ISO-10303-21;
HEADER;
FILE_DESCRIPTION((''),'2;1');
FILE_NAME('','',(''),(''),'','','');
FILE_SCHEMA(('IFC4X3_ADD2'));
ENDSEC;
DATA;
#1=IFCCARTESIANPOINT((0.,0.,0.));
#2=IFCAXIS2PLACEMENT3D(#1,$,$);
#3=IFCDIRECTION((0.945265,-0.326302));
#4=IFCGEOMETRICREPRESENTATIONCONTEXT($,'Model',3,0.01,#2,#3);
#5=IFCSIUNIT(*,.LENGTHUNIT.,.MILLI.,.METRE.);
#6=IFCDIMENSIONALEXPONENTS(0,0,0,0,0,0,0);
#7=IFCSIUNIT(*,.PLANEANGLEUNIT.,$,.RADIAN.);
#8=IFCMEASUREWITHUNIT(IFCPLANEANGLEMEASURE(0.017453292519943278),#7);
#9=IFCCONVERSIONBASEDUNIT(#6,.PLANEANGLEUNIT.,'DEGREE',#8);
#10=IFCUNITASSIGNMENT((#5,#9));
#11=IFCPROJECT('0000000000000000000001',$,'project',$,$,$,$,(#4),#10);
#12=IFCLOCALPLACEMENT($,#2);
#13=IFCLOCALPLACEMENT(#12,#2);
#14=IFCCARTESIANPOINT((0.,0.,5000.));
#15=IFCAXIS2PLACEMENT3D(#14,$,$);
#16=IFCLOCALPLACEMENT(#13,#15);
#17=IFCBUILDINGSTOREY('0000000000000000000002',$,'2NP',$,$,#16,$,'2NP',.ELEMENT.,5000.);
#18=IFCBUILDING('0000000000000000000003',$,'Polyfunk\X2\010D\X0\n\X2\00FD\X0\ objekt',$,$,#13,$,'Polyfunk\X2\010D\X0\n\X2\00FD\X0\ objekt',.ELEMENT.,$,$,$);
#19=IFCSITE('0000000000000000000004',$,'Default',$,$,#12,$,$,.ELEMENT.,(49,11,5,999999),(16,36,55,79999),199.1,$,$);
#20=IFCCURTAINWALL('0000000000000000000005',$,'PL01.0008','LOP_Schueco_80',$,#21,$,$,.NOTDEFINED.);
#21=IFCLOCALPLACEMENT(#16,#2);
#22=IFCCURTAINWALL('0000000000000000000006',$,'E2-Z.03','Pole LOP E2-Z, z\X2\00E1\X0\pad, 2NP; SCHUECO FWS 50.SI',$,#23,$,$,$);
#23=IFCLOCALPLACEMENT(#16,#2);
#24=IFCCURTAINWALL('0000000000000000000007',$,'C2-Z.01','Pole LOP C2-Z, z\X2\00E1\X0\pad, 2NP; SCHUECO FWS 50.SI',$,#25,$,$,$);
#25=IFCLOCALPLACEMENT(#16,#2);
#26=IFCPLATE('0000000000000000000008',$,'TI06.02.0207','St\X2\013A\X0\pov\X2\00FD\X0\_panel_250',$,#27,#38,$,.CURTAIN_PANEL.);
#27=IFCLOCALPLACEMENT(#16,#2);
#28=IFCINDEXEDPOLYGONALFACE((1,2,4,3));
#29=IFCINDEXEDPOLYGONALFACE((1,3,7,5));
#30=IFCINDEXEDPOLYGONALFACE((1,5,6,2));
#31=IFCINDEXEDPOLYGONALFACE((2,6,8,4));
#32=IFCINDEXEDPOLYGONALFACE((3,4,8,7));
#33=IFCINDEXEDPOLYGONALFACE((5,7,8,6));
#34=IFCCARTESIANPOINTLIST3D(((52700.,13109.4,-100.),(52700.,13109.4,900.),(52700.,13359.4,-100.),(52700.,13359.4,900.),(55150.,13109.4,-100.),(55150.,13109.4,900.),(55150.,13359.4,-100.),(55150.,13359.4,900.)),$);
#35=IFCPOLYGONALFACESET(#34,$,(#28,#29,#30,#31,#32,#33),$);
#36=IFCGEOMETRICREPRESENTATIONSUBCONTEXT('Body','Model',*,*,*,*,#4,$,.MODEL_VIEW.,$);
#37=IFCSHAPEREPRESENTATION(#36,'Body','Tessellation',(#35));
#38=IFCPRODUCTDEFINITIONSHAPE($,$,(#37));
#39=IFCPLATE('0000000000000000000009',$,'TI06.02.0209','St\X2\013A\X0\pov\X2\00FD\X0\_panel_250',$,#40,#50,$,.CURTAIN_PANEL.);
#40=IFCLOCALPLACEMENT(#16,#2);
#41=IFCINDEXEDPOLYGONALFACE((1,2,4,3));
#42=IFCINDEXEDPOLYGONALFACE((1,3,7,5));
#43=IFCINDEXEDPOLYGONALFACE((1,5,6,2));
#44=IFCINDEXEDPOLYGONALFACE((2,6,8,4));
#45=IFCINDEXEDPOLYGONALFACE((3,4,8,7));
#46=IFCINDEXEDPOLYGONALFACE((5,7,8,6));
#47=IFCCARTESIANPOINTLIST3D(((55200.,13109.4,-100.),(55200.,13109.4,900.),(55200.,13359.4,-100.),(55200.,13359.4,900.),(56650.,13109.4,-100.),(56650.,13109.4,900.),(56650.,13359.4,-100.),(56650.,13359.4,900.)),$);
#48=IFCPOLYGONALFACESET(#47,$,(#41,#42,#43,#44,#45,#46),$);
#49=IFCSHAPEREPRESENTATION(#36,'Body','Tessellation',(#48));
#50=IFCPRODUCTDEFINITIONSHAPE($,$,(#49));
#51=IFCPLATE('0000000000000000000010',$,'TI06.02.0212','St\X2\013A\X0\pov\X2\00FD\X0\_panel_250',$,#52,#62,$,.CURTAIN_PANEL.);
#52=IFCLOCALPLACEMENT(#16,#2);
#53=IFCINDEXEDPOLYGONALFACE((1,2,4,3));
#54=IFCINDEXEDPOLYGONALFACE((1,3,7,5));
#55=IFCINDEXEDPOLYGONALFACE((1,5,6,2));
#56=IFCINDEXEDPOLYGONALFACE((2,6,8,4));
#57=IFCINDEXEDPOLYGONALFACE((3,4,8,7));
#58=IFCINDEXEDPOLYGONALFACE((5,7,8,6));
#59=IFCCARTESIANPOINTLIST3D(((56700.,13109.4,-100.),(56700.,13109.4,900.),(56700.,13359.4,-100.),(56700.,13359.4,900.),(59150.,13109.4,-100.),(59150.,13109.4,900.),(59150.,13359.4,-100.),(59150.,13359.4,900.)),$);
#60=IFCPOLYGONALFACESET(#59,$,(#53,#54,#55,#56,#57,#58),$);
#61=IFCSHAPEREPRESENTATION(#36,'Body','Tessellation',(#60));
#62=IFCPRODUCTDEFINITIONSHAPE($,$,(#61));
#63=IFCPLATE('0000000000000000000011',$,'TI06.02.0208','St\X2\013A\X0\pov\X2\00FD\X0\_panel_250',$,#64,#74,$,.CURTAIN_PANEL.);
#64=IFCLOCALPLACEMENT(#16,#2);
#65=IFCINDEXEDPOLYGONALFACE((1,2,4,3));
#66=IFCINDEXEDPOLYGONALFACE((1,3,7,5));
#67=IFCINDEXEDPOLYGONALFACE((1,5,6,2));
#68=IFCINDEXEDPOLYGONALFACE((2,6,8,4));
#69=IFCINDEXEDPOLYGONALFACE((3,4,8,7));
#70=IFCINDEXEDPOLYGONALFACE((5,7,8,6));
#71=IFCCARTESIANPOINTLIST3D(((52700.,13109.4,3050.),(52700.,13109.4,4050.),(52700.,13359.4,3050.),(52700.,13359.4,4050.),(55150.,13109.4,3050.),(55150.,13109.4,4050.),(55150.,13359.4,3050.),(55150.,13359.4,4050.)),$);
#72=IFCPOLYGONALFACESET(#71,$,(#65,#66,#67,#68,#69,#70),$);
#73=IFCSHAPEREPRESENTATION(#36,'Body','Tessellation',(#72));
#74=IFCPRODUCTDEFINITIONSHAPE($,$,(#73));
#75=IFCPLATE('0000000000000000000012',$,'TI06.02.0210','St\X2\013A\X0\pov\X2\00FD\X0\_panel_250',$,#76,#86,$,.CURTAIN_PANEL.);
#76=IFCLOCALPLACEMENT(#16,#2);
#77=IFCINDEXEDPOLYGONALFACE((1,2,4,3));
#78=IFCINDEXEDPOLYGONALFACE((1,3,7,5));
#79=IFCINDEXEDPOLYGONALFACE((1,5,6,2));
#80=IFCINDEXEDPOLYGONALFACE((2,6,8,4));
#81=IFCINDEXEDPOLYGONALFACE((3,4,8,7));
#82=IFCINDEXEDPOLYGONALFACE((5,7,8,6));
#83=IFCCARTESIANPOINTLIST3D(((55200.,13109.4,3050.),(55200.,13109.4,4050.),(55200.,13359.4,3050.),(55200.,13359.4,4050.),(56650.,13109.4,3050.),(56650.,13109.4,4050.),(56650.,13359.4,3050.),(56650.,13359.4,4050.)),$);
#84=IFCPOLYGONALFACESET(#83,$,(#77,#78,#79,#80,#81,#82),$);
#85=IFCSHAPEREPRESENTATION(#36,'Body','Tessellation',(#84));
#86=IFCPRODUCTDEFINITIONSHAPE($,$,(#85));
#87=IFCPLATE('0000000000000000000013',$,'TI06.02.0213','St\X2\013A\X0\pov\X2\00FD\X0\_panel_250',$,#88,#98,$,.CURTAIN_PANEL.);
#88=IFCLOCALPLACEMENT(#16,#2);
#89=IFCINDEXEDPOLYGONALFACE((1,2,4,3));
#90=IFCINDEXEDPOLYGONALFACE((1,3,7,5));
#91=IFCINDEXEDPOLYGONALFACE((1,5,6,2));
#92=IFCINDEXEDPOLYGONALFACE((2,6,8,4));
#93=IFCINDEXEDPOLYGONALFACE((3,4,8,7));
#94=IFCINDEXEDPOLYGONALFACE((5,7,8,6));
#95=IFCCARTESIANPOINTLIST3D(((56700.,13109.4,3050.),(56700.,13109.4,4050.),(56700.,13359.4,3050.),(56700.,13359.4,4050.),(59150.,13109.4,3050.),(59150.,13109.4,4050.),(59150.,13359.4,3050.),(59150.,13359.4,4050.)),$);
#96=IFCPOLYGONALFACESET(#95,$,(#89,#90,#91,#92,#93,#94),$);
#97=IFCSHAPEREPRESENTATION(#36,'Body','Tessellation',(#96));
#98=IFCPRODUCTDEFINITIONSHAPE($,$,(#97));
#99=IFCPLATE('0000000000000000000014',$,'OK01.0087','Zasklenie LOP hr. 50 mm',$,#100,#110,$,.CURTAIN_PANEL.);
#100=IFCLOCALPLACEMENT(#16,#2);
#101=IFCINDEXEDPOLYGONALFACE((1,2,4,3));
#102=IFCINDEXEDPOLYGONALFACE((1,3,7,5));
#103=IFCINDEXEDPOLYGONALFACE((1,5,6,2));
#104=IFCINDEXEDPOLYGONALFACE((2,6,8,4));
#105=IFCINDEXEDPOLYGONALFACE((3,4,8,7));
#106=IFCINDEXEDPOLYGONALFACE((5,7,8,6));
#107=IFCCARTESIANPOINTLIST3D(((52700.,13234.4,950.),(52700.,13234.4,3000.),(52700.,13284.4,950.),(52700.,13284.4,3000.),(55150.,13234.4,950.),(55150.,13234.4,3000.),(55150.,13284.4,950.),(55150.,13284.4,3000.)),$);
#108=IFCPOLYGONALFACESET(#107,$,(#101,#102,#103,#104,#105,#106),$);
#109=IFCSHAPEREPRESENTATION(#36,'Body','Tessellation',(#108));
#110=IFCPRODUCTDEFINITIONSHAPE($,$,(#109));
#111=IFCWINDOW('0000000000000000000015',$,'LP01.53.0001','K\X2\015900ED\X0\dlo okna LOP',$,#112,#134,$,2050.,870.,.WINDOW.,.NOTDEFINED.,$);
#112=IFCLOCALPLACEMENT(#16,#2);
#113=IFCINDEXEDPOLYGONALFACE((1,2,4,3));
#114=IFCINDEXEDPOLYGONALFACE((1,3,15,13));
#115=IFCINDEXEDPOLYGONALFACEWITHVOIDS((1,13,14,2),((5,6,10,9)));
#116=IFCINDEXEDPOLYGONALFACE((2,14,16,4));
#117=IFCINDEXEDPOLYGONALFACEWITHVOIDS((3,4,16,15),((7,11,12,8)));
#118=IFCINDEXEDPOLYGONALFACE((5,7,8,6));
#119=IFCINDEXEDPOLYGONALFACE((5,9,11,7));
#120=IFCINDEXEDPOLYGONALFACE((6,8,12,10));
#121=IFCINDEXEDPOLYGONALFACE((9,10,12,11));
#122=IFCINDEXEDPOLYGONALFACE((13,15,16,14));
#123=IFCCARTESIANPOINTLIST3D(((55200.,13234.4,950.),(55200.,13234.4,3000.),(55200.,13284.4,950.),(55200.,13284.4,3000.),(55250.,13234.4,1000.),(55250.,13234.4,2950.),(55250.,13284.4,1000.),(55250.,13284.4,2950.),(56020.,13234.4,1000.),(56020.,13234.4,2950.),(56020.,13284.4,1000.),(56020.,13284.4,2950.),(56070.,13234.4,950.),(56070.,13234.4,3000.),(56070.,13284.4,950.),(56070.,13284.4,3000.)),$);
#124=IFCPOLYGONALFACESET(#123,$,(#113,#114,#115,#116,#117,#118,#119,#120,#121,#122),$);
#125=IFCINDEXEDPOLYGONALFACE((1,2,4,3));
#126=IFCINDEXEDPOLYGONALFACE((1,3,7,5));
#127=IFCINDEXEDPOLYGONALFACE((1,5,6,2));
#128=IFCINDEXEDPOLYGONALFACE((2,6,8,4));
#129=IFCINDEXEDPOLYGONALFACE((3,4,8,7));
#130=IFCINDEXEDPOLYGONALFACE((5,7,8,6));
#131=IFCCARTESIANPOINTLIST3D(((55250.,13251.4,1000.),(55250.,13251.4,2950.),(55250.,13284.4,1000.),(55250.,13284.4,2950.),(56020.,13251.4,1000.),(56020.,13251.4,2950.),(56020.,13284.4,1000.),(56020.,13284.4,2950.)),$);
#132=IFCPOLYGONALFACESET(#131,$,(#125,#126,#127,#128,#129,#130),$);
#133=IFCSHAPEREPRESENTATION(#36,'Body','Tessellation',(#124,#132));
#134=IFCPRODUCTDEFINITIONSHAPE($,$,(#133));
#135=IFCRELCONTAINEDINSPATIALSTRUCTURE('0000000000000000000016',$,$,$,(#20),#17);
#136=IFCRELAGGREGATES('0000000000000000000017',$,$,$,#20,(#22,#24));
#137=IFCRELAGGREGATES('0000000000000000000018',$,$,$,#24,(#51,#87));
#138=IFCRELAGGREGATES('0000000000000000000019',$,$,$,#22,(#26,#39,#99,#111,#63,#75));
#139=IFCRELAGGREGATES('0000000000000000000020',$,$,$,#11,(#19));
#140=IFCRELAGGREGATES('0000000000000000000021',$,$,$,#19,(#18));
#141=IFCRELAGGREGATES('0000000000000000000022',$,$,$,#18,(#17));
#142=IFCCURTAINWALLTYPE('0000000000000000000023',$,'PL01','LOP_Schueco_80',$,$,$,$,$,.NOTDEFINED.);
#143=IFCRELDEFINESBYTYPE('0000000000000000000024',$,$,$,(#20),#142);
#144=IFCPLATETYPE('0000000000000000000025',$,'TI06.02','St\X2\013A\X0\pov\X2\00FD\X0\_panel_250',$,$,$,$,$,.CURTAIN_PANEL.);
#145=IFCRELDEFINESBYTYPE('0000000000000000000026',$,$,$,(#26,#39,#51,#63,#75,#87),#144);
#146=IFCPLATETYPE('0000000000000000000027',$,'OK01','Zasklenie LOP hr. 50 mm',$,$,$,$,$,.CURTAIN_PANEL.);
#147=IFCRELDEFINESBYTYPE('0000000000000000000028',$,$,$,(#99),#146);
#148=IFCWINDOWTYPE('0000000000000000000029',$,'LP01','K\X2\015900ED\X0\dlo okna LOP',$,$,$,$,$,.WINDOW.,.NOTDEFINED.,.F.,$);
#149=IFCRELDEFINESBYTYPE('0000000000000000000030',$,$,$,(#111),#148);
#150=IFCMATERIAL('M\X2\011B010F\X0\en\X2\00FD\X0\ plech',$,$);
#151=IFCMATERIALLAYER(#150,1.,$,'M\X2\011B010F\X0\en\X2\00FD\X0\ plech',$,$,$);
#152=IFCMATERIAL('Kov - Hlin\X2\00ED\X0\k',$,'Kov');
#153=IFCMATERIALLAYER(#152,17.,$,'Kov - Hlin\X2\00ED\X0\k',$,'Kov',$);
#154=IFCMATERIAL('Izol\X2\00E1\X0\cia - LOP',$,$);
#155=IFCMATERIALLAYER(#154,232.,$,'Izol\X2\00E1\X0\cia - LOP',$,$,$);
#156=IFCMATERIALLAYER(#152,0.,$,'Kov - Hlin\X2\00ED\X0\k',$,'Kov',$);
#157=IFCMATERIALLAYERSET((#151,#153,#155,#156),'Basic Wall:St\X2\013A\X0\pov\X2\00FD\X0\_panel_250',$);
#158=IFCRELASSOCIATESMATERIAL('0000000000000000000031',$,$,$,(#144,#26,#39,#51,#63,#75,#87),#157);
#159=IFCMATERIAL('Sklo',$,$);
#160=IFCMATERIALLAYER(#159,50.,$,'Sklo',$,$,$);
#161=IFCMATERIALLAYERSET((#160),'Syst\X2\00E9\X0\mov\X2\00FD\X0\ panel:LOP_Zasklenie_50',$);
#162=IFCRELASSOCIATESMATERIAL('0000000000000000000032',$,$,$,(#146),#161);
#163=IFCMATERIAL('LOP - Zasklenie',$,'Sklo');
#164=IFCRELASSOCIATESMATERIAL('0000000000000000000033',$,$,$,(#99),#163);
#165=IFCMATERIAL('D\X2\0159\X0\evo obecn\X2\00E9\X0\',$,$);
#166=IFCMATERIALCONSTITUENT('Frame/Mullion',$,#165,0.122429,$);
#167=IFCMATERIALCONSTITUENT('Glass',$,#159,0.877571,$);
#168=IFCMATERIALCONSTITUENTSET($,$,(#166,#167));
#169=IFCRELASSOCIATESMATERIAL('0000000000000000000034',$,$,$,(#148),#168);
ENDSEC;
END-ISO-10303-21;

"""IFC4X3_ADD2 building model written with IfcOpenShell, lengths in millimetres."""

from ifc_helpers import new_model, entity, si_unit, converted_unit, direction, frame, frame_2d, origin, origin_2d_with_axis, place, context, subcontext, project, spatial, polyline, rectangle, outline, extrude, source, transform, mapped, material, layer, layer_set, layer_usage, constituent, constituent_set, type_object, type_shapes, element, aggregate, save


model = new_model("IFC4X3_ADD2")

# Units and contexts
model_context = context("Model", 3, precision=0.01, world=origin(), true_north=direction((0.945265, -0.326302)))
body_context = subcontext(model_context, "Body", "Model", "MODEL_VIEW")
ifc_project = project(units=[si_unit("LENGTHUNIT", "METRE", prefix="MILLI"), converted_unit("PLANEANGLEUNIT", "DEGREE", entity("IfcPlaneAngleMeasure", 0.017453292519943278), si_unit("PLANEANGLEUNIT", "RADIAN"), dimensions=[0, 0, 0, 0, 0, 0, 0])], contexts=[model_context])

# Site, building, storey
site_placement = place(None, origin())
site = spatial("IfcSite", under=ifc_project, at=site_placement, Name="Default", CompositionType="ELEMENT", RefLatitude=(49, 11, 5, 999999), RefLongitude=(16, 36, 55, 79999), RefElevation=199.1)
building_placement = place(site_placement, origin())
building = spatial("IfcBuilding", under=site, at=building_placement, Name="Polyfunkčný objekt", LongName="Polyfunkčný objekt", CompositionType="ELEMENT")
storey_placement = place(building_placement, frame((0.0, 0.0, 5000.0)))
storey = spatial("IfcBuildingStorey", under=building, at=storey_placement, Name="2NP", LongName="2NP", CompositionType="ELEMENT", Elevation=5000.0)

# Curtain walls, plates, window
curtain_wall_type = type_object("IfcCurtainWallType", Name="PL01", Description="LOP_Schueco_80", PredefinedType="NOTDEFINED")
curtain_wall_1_placement = place(storey_placement, frame((0.0, 0.0, -5000.0)))
curtain_wall_1 = element("IfcCurtainWall", 1, at=curtain_wall_1_placement, inside=storey, type_object=curtain_wall_type, Name="PL01.0008", Description="LOP_Schueco_80", PredefinedType="NOTDEFINED")
curtain_wall_2 = element("IfcCurtainWall", 2, Name="E2-Z.03", Description="Pole LOP E2-Z, západ, 2NP; SCHUECO FWS 50.SI")
curtain_wall_3 = element("IfcCurtainWall", 3, Name="C2-Z.01", Description="Pole LOP C2-Z, západ, 2NP; SCHUECO FWS 50.SI")
aggregate(curtain_wall_1, [curtain_wall_2, curtain_wall_3])
ifc_material_1 = material(Name="Měďený plech")
ifc_layer_1 = layer(ifc_material_1, 1.0, Name="Měďený plech")
ifc_material_2 = material(Name="Kov - Hliník", Category="Kov")
ifc_layer_2 = layer(ifc_material_2, 17.0, Name="Kov - Hliník", Category="Kov")
ifc_material_3 = material(Name="Izolácia - LOP")
ifc_layer_3 = layer(ifc_material_3, 232.0, Name="Izolácia - LOP")
ifc_layer_4 = layer(ifc_material_2, 0.0, Name="Kov - Hliník", Category="Kov")
ifc_layer_set_1 = layer_set([ifc_layer_1, ifc_layer_2, ifc_layer_3, ifc_layer_4], Name="Basic Wall:Stĺpový_panel_250")
ifc_layer_usage_1 = layer_usage(ifc_layer_set_1, "AXIS2", "NEGATIVE", 125.0)
plate_type_1 = type_object("IfcPlateType", Name="TI06.02", Description="Stĺpový_panel_250", PredefinedType="CURTAIN_PANEL", material=ifc_layer_set_1)
plate_1_placement = place(storey_placement, frame((52700.0, 13234.4, -100.0)))
plate_1 = element("IfcPlate", 4, at=plate_1_placement, type_object=plate_type_1, material=ifc_layer_usage_1, Name="TI06.02.0207", Description="Stĺpový_panel_250", PredefinedType="CURTAIN_PANEL", context=body_context, shape_type="SweptSolid", body=[
    extrude(rectangle(XDim=250.0, YDim=2450.0, at=origin_2d_with_axis()), frame((1225.0, 0.0, 0.0), z_axis=(0.0, 0.0, 1.0), x_axis=(0.0, 1.0, 0.0)), (0.0, 0.0, 1.0), 1000.0),
])
ifc_layer_usage_2 = layer_usage(ifc_layer_set_1, "AXIS2", "NEGATIVE", 125.0)
plate_2_placement = place(storey_placement, frame((55200.0, 13234.4, -100.0)))
plate_2 = element("IfcPlate", 5, at=plate_2_placement, type_object=plate_type_1, material=ifc_layer_usage_2, Name="TI06.02.0209", Description="Stĺpový_panel_250", PredefinedType="CURTAIN_PANEL", context=body_context, shape_type="SweptSolid", body=[
    extrude(rectangle(XDim=250.0, YDim=1450.0, at=origin_2d_with_axis()), frame((725.0, 0.0, 0.0), z_axis=(0.0, 0.0, 1.0), x_axis=(0.0, 1.0, 0.0)), (0.0, 0.0, 1.0), 1000.0),
])
ifc_layer_usage_3 = layer_usage(ifc_layer_set_1, "AXIS2", "NEGATIVE", 125.0)
plate_3_placement = place(storey_placement, frame((56700.0, 13234.4, -100.0)))
plate_3 = element("IfcPlate", 6, at=plate_3_placement, type_object=plate_type_1, material=ifc_layer_usage_3, Name="TI06.02.0212", Description="Stĺpový_panel_250", PredefinedType="CURTAIN_PANEL", context=body_context, shape_type="SweptSolid", body=[
    extrude(rectangle(XDim=250.0, YDim=2450.0, at=frame_2d((0.0, 0.0), x_axis=(1.0, 0.0))), frame((1225.0, 0.0, 0.0), z_axis=(0.0, 0.0, 1.0), x_axis=(0.0, 1.0, 0.0)), (0.0, 0.0, 1.0), 1000.0),
])
ifc_layer_usage_4 = layer_usage(ifc_layer_set_1, "AXIS2", "NEGATIVE", 125.0)
plate_4_placement = place(storey_placement, frame((52700.0, 13234.4, 3050.0)))
plate_4 = element("IfcPlate", 7, at=plate_4_placement, type_object=plate_type_1, material=ifc_layer_usage_4, Name="TI06.02.0208", Description="Stĺpový_panel_250", PredefinedType="CURTAIN_PANEL", context=body_context, shape_type="SweptSolid", body=[
    extrude(rectangle(XDim=250.0, YDim=2450.0, at=origin_2d_with_axis()), frame((1225.0, 0.0, 0.0), z_axis=(0.0, 0.0, 1.0), x_axis=(0.0, 1.0, 0.0)), (0.0, 0.0, 1.0), 1000.0),
])
ifc_layer_usage_5 = layer_usage(ifc_layer_set_1, "AXIS2", "NEGATIVE", 125.0)
plate_5_placement = place(storey_placement, frame((55200.0, 13234.4, 3050.0)))
plate_5 = element("IfcPlate", 8, at=plate_5_placement, type_object=plate_type_1, material=ifc_layer_usage_5, Name="TI06.02.0210", Description="Stĺpový_panel_250", PredefinedType="CURTAIN_PANEL", context=body_context, shape_type="SweptSolid", body=[
    extrude(rectangle(XDim=250.0, YDim=1450.0, at=origin_2d_with_axis()), frame((725.0, 0.0, 0.0), z_axis=(0.0, 0.0, 1.0), x_axis=(0.0, 1.0, 0.0)), (0.0, 0.0, 1.0), 1000.0),
])
ifc_layer_usage_6 = layer_usage(ifc_layer_set_1, "AXIS2", "NEGATIVE", 125.0)
plate_6_placement = place(storey_placement, frame((56700.0, 13234.4, 3050.0)))
plate_6 = element("IfcPlate", 9, at=plate_6_placement, type_object=plate_type_1, material=ifc_layer_usage_6, Name="TI06.02.0213", Description="Stĺpový_panel_250", PredefinedType="CURTAIN_PANEL", context=body_context, shape_type="SweptSolid", body=[
    extrude(rectangle(XDim=250.0, YDim=2450.0, at=frame_2d((0.0, 0.0), x_axis=(1.0, 0.0))), frame((1225.0, 0.0, 0.0), z_axis=(0.0, 0.0, 1.0), x_axis=(0.0, 1.0, 0.0)), (0.0, 0.0, 1.0), 1000.0),
])
aggregate(curtain_wall_3, [plate_3, plate_6])
ifc_material_4 = material(Name="LOP - Zasklenie", Category="Sklo")
ifc_material_5 = material(Name="Sklo")
ifc_layer_5 = layer(ifc_material_5, 50.0, Name="Sklo")
ifc_layer_set_2 = layer_set([ifc_layer_5], Name="Systémový panel:LOP_Zasklenie_50")
plate_type_2 = type_object("IfcPlateType", Name="OK01", Description="Zasklenie LOP hr. 50 mm", PredefinedType="CURTAIN_PANEL", material=ifc_layer_set_2)
shared_shape_1 = source(origin(), body_context, "Body", "SweptSolid", [
    extrude(rectangle(XDim=50.0, YDim=2450.0, at=origin_2d_with_axis()), frame((0.0, 25.0, 0.0), z_axis=(0.0, 0.0, 1.0), x_axis=(0.0, 1.0, 0.0)), (0.0, 0.0, 1.0), 2050.0),
])
type_shapes(plate_type_2, [shared_shape_1])
plate_7_placement = place(curtain_wall_1_placement, frame((53925.0, 13234.4, 5950.0)))
plate_7 = element("IfcPlate", 10, at=plate_7_placement, type_object=plate_type_2, material=ifc_material_4, Name="OK01.0087", Description="Zasklenie LOP hr. 50 mm", PredefinedType="CURTAIN_PANEL", context=body_context, shape_type="MappedRepresentation", body=[
    mapped(shared_shape_1, transform((0.0, 0.0, 0.0), scale=1.0)),
])
ifc_material_6 = material(Name="Dřevo obecné")
ifc_constituent_1 = constituent(ifc_material_6, Name="Frame/Mullion", fraction=0.122429)
ifc_constituent_2 = constituent(ifc_material_5, Name="Glass", fraction=0.877571)
ifc_constituent_set = constituent_set(constituents=[ifc_constituent_1, ifc_constituent_2])
window_type = type_object("IfcWindowType", Name="LP01", Description="Křídlo okna LOP", ParameterTakesPrecedence=False, PartitioningType="NOTDEFINED", PredefinedType="WINDOW", material=ifc_constituent_set)
shared_shape_2 = source(origin(), body_context, "Body", "SweptSolid", [
    extrude(outline(polyline([(-1025.0, -435.0), (1025.0, -435.0), (1025.0, 435.0), (-1025.0, 435.0), (-1025.0, -435.0)]), holes=[polyline([(-975.0, -385.0), (-975.0, 385.0), (975.0, 385.0), (975.0, -385.0), (-975.0, -385.0)])]), frame((0.0, 0.0, 1025.0), z_axis=(0.0, 1.0, 0.0), x_axis=(0.0, 0.0, -1.0)), (0.0, 0.0, 1.0), 50.0),
    extrude(rectangle(XDim=33.0, YDim=770.0, at=origin_2d_with_axis()), frame((0.0, 33.5, 50.0), z_axis=(0.0, 0.0, 1.0), x_axis=(0.0, -1.0, 0.0)), (0.0, 0.0, 1.0), 1950.0),
])
type_shapes(window_type, [shared_shape_2])
window_placement = place(curtain_wall_1_placement, frame((55635.0, 13234.4, 5950.0)))
window = element("IfcWindow", 11, at=window_placement, type_object=window_type, Name="LP01.53.0001", Description="Křídlo okna LOP", OverallHeight=2050.0, OverallWidth=870.0, PartitioningType="NOTDEFINED", PredefinedType="WINDOW", context=body_context, shape_type="MappedRepresentation", body=[
    mapped(shared_shape_2, transform((0.0, 0.0, 0.0), scale=1.0)),
])
aggregate(curtain_wall_2, [plate_1, plate_2, plate_7, window, plate_4, plate_5])

save(model, "model.ifc")
